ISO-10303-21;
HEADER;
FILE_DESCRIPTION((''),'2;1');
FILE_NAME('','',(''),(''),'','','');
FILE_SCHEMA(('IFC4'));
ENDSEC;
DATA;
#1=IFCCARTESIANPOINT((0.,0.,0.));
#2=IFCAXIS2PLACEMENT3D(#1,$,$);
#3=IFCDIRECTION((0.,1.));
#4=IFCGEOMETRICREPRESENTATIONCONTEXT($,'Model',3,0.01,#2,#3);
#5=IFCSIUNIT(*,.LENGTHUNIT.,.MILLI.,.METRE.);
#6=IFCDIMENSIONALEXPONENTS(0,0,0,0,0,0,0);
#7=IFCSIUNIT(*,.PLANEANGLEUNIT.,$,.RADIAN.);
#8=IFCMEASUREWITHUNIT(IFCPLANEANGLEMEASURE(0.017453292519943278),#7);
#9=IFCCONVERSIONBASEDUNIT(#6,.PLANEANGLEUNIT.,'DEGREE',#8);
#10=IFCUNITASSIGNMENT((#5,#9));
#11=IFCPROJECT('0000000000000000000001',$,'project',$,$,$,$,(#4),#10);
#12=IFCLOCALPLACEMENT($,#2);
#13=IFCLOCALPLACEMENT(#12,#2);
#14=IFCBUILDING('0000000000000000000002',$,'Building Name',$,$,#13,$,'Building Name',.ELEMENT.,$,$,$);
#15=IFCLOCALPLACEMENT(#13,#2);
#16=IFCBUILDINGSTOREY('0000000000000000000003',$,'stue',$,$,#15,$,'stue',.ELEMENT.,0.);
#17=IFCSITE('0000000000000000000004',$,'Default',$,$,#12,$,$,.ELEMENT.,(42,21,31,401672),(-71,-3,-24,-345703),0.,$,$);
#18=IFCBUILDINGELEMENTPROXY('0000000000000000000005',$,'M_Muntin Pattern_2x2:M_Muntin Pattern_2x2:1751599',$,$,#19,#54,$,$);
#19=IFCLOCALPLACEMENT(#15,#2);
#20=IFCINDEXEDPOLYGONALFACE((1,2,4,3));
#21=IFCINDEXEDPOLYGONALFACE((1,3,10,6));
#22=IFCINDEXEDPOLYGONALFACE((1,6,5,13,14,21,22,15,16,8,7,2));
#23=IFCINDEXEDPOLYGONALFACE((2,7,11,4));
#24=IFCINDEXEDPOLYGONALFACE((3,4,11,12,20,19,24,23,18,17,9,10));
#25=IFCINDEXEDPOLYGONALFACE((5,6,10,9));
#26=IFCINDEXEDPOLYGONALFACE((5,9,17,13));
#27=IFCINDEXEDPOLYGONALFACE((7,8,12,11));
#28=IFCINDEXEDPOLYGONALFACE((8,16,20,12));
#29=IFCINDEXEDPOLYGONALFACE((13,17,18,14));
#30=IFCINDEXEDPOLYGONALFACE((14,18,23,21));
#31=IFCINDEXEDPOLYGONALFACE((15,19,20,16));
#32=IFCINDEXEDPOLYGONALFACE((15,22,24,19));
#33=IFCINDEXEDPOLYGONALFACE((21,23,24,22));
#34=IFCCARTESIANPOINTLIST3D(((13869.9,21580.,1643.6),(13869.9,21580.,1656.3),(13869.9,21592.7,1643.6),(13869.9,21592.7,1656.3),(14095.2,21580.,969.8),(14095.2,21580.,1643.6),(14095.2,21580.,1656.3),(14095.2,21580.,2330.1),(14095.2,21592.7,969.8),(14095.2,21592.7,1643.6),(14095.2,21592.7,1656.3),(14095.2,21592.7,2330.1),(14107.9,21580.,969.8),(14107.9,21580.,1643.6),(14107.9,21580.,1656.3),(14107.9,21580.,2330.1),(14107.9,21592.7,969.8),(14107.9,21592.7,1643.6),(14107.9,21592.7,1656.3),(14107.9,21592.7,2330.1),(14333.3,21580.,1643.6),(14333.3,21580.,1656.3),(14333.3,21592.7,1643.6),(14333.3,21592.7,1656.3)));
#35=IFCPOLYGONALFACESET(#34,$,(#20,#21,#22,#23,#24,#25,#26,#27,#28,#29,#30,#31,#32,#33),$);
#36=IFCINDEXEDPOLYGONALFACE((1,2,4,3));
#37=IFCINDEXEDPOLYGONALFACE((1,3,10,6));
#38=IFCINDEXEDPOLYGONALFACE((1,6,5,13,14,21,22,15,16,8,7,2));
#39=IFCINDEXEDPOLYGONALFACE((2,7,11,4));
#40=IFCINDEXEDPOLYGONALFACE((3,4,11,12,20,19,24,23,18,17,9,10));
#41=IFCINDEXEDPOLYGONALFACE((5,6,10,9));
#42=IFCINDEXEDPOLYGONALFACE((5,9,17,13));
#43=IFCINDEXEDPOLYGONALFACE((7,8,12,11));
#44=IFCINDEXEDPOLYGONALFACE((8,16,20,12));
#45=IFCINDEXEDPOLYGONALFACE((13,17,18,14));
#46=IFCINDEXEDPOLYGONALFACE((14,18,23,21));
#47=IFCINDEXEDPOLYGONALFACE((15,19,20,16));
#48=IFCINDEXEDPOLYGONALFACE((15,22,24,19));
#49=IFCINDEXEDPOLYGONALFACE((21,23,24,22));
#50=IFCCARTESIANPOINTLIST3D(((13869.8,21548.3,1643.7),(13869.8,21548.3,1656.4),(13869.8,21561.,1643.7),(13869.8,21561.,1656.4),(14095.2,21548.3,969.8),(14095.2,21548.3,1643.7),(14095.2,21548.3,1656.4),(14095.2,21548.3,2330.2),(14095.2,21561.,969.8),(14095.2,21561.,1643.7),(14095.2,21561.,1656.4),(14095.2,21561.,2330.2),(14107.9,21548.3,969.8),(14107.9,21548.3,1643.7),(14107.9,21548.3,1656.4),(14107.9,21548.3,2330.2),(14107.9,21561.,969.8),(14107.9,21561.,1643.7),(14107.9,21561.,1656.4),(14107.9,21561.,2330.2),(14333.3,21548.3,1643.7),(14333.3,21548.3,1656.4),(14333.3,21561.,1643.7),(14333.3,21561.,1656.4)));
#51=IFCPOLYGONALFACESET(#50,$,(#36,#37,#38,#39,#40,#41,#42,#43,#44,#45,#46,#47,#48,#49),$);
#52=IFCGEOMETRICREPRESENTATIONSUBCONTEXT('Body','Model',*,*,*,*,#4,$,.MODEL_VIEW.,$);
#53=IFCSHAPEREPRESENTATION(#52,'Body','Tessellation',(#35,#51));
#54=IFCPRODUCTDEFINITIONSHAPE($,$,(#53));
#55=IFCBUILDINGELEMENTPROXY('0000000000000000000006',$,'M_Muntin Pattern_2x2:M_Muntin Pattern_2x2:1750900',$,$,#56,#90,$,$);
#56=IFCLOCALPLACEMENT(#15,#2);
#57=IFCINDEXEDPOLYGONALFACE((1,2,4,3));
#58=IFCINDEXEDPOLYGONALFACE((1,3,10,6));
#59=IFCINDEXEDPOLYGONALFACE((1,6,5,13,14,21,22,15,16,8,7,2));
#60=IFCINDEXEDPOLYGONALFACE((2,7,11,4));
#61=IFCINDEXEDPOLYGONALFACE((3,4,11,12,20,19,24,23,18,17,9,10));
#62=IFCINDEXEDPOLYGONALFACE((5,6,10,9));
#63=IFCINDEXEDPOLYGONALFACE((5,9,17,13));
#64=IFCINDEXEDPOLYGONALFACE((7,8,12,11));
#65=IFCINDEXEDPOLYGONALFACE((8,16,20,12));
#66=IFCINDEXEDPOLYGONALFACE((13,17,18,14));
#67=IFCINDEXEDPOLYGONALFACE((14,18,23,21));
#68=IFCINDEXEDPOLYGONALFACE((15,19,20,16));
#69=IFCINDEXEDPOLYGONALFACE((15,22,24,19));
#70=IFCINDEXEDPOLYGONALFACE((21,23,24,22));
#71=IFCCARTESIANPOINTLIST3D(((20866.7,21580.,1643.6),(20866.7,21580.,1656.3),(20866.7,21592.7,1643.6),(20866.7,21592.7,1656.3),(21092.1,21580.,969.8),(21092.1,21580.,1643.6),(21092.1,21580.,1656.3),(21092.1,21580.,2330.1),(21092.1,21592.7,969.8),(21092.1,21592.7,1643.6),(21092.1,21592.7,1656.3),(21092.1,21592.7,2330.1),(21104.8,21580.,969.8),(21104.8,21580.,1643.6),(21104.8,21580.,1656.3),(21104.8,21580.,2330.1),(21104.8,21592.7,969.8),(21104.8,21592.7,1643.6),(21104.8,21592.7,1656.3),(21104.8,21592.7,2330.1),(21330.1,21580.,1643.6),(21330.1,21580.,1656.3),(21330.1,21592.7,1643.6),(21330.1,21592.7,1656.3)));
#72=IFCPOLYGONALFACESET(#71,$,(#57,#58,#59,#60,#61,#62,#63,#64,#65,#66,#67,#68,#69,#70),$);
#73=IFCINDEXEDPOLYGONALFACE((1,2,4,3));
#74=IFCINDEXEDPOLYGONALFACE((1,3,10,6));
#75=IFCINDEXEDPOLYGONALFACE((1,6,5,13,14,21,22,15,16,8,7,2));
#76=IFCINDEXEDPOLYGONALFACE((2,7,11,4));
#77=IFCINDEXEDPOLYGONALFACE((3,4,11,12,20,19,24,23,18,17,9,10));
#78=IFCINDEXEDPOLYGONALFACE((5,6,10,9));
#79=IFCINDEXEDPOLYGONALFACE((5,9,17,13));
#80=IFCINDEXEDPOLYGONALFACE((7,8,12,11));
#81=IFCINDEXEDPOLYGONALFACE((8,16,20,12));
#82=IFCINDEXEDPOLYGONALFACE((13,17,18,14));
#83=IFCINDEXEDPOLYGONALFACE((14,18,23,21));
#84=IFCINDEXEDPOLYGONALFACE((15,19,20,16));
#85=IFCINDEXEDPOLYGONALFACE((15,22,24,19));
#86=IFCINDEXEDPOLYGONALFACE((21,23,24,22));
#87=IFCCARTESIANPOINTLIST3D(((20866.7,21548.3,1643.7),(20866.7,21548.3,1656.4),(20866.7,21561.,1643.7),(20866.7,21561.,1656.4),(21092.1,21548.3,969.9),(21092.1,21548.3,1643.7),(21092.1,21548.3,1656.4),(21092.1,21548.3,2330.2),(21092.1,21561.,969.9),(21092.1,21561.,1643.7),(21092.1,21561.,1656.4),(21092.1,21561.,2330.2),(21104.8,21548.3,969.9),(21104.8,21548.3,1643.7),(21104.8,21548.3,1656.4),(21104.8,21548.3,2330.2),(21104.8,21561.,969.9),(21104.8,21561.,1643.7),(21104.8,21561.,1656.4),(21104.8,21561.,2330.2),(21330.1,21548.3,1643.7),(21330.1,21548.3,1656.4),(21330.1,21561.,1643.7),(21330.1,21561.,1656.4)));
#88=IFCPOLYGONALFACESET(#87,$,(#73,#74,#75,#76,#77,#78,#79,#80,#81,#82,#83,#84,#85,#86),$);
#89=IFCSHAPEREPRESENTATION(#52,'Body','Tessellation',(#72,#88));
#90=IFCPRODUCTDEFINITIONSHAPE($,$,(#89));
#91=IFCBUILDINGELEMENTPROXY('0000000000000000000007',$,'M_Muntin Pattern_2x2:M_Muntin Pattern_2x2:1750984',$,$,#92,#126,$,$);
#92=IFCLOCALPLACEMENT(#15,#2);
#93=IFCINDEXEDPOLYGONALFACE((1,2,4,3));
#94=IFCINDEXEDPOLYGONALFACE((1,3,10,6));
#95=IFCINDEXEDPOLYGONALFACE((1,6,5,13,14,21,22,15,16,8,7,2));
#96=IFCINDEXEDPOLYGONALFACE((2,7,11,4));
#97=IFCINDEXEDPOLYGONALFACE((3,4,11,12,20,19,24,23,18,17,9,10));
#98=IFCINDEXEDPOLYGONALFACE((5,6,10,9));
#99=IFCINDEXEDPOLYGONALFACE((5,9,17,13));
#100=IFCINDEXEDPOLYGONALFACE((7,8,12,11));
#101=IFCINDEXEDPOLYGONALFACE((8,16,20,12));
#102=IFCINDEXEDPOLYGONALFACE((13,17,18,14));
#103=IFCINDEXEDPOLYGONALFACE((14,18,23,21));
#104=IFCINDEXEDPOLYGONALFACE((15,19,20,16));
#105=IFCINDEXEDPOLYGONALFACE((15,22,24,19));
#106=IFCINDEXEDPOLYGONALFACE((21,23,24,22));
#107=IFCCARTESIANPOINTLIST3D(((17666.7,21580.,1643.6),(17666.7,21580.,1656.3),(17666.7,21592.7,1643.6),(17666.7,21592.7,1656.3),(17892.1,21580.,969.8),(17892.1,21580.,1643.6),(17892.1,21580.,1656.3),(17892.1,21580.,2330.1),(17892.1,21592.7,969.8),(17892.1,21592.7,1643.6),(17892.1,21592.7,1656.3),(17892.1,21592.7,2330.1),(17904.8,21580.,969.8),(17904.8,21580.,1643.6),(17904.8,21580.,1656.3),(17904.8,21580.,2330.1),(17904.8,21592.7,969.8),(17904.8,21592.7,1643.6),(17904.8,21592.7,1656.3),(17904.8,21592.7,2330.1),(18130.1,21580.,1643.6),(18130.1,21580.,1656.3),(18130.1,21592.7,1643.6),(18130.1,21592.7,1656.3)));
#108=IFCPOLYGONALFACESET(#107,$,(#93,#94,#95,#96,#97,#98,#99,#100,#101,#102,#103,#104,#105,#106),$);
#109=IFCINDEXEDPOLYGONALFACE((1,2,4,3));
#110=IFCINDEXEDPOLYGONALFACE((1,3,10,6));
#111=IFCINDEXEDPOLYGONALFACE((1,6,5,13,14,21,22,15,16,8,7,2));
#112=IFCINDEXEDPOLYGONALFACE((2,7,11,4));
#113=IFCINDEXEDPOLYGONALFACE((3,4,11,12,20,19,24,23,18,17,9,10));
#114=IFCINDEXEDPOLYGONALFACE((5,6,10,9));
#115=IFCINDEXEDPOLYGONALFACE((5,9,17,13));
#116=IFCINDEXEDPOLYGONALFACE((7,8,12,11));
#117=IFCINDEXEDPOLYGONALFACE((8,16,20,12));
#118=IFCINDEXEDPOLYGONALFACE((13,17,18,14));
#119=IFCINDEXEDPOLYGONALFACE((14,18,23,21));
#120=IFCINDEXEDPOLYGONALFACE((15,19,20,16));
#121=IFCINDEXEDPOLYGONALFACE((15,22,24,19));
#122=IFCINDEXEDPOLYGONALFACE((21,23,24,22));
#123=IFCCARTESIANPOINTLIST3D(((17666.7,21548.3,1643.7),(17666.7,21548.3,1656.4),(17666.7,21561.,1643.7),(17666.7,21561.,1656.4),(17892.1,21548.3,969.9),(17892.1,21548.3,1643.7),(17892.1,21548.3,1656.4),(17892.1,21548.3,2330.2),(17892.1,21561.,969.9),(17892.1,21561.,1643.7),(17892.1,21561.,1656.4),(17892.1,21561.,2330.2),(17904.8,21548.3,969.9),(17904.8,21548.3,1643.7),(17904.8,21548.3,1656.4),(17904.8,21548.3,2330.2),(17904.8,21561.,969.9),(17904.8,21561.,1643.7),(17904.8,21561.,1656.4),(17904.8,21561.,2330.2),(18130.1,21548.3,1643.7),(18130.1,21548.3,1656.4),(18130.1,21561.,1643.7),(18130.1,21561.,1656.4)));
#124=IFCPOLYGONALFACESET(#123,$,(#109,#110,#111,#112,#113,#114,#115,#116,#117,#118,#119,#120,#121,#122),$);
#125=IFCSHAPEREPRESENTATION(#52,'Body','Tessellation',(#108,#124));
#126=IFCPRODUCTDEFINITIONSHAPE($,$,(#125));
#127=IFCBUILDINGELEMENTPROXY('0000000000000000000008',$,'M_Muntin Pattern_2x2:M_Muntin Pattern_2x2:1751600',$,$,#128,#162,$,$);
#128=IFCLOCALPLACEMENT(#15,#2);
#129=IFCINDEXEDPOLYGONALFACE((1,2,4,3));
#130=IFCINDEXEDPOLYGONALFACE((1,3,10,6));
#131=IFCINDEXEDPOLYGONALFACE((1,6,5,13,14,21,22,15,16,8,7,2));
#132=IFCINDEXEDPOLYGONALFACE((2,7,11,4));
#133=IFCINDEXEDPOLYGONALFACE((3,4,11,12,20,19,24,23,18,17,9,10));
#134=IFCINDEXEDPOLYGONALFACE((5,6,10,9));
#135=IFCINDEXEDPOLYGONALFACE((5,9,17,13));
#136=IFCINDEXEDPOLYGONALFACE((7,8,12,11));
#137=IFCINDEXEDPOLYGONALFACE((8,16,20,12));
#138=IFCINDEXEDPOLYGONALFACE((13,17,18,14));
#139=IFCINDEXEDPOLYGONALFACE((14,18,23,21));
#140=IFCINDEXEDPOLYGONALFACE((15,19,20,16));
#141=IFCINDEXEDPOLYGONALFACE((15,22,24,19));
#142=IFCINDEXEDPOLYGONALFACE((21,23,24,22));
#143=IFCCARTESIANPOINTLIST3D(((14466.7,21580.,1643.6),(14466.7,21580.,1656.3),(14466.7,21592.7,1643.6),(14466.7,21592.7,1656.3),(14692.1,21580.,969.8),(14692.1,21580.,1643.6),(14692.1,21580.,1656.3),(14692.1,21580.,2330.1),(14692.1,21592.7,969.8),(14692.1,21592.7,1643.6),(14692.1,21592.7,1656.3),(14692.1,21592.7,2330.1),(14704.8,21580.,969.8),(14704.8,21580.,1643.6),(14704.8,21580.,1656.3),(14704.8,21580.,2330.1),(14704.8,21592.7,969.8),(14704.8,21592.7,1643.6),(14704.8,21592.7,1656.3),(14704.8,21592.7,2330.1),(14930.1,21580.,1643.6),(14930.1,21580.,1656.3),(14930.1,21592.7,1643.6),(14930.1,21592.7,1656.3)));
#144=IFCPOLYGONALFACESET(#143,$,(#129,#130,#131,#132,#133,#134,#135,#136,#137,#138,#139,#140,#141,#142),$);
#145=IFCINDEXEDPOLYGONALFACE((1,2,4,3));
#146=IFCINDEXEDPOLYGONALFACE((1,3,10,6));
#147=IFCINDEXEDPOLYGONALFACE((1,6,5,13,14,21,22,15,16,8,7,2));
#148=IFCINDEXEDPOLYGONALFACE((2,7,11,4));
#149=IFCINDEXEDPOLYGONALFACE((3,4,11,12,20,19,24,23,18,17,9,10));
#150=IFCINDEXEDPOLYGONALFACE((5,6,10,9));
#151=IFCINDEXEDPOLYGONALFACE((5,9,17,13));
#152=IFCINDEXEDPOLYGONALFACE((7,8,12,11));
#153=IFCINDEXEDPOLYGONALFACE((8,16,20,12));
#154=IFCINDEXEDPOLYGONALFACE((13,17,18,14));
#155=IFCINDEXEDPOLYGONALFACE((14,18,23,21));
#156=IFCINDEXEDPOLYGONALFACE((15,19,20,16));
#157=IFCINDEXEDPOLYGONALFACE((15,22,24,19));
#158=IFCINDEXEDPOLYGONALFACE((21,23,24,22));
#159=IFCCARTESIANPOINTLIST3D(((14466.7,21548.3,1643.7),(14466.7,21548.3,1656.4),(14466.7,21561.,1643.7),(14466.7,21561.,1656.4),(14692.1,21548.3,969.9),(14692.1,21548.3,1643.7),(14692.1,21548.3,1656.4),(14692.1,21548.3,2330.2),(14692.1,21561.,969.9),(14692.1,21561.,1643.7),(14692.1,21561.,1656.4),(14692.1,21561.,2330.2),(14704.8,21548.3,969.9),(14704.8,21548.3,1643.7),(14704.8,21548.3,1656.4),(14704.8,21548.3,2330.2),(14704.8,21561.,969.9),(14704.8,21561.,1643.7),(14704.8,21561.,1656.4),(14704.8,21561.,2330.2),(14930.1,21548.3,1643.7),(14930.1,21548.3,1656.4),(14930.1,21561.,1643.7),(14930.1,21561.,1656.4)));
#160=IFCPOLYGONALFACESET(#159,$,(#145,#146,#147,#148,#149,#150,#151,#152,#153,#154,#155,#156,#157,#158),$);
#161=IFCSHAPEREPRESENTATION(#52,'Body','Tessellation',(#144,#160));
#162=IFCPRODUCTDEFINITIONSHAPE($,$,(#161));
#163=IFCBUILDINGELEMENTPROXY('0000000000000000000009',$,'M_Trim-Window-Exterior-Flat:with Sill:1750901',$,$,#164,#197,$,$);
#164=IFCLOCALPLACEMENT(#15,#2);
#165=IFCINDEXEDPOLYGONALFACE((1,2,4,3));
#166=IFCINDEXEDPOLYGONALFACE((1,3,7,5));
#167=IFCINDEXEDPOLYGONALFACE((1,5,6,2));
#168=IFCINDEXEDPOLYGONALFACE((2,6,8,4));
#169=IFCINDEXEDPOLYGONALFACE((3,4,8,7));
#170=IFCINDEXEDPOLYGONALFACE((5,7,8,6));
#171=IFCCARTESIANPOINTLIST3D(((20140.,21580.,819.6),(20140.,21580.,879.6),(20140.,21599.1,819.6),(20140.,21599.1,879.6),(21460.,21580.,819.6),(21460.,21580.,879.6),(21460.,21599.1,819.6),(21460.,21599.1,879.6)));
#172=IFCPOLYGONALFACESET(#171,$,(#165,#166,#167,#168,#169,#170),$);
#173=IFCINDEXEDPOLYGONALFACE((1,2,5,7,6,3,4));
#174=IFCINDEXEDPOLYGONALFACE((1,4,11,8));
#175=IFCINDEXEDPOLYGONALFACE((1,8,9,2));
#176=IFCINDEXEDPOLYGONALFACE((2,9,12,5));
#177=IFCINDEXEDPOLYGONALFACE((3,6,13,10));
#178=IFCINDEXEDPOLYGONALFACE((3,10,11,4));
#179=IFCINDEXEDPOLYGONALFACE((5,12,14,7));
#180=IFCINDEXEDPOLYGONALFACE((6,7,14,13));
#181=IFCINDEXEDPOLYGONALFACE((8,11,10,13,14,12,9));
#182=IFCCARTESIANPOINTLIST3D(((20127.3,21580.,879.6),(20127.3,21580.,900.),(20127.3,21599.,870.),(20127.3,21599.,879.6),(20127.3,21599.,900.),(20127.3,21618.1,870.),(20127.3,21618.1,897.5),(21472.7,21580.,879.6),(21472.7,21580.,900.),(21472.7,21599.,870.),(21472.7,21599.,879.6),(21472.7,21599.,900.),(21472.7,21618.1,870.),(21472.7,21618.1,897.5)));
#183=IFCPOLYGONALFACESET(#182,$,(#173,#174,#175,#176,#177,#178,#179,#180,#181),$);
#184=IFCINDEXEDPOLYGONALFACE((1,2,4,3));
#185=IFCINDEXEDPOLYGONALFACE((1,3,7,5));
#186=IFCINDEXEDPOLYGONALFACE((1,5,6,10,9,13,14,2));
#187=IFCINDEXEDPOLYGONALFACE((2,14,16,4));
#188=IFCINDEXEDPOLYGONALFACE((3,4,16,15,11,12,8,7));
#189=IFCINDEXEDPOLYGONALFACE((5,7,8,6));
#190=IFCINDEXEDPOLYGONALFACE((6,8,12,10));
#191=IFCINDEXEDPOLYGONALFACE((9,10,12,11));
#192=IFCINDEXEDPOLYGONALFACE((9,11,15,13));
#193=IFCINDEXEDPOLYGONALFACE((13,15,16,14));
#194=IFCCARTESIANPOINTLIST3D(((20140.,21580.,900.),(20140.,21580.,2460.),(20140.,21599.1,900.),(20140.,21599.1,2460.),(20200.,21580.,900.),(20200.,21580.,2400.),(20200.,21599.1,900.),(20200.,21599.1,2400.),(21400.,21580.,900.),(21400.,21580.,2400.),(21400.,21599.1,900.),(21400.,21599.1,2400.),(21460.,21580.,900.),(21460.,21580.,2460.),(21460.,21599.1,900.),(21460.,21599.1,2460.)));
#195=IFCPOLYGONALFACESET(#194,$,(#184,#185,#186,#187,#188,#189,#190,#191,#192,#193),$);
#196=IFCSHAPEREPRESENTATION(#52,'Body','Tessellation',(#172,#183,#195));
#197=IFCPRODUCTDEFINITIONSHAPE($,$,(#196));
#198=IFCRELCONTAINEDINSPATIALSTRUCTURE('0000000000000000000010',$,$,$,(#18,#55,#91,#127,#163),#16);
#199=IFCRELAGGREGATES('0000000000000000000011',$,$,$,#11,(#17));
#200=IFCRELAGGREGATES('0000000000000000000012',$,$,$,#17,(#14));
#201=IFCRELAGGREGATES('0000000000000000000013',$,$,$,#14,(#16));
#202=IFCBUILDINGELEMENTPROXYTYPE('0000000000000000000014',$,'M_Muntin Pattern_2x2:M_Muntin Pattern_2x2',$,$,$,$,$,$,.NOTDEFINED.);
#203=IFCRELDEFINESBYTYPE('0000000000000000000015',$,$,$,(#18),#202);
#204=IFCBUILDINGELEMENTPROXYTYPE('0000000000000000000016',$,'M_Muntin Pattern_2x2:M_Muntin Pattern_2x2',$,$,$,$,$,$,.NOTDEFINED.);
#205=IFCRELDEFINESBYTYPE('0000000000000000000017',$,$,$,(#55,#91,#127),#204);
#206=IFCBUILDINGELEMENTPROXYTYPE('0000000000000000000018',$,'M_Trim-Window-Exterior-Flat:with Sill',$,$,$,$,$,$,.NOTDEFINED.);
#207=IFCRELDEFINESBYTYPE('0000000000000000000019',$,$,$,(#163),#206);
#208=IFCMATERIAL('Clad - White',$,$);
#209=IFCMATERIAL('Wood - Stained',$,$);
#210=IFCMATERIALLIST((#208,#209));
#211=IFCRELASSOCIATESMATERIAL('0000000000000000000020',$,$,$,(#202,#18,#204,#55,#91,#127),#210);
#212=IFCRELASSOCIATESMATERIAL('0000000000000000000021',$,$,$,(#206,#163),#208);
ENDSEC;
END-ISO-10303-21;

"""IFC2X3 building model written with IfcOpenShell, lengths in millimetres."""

from ifc_helpers import new_model, entity, si_unit, converted_unit, direction, frame, frame_2d, origin, place, context, subcontext, project, spatial, polyline, rectangle, outline, extrude, source, transform, mapped, material, material_list, type_object, type_shapes, element, save


model = new_model("IFC2X3")

# Units and contexts
model_context = context("Model", 3, precision=0.01, world=origin(), true_north=direction((0.0, 1.0)))
body_context = subcontext(model_context, "Body", "Model", "MODEL_VIEW")
ifc_project = project(units=[si_unit("LENGTHUNIT", "METRE", prefix="MILLI"), converted_unit("PLANEANGLEUNIT", "DEGREE", entity("IfcPlaneAngleMeasure", 0.017453292519943278), si_unit("PLANEANGLEUNIT", "RADIAN"), dimensions=[0, 0, 0, 0, 0, 0, 0])], contexts=[model_context])

# Site, building, storey
site_placement = place(None, origin())
site = spatial("IfcSite", under=ifc_project, at=site_placement, Name="Default", CompositionType="ELEMENT", RefLatitude=(42, 21, 31, 401672), RefLongitude=(-71, -3, -24, -345703), RefElevation=0.0)
building_placement = place(site_placement, origin())
building = spatial("IfcBuilding", under=site, at=building_placement, Name="Building Name", LongName="Building Name", CompositionType="ELEMENT")
storey_placement = place(building_placement, origin())
storey = spatial("IfcBuildingStorey", under=building, at=storey_placement, Name="stue", LongName="stue", CompositionType="ELEMENT", Elevation=0.0)

# Building element proxies
ifc_material_1 = material(Name="Clad - White")
ifc_material_2 = material(Name="Wood - Stained")
ifc_material_list = material_list([ifc_material_1, ifc_material_2])
building_element_proxy_type_1 = type_object("IfcBuildingElementProxyType", Name="M_Muntin Pattern_2x2:M_Muntin Pattern_2x2", PredefinedType="NOTDEFINED", material=ifc_material_list)
shared_shape_1 = source(origin(), body_context, "Body", "SweptSolid", [
    extrude(outline(polyline([(6.4, -6.4), (680.1, -6.4), (680.1, 6.3), (6.4, 6.3), (6.4, 231.7), (-6.3, 231.7), (-6.3, 6.3), (-680.2, 6.3), (-680.2, -6.4), (-6.3, -6.4), (-6.3, -231.7), (6.4, -231.7), (6.4, -6.4)])), frame((0.0, 9.5, 680.1), z_axis=(0.0, 1.0, 0.0), x_axis=(0.0, 0.0, 1.0)), (0.0, 0.0, 1.0), 12.7),
    extrude(outline(polyline([(6.4, -6.4), (680.2, -6.4), (680.2, 6.3), (6.4, 6.3), (6.4, 231.7), (-6.3, 231.7), (-6.3, 6.3), (-680.2, 6.3), (-680.2, -6.4), (-6.3, -6.4), (-6.3, -231.7), (6.4, -231.7), (6.4, -6.4)])), frame((0.0, -22.2, 680.2), z_axis=(0.0, 1.0, 0.0), x_axis=(0.0, 0.0, 1.0)), (0.0, 0.0, 1.0), 12.7),
])
type_shapes(building_element_proxy_type_1, [shared_shape_1])
for number, where, name in (
    (1, (14101.6, 21570.5, 969.8), "M_Muntin Pattern_2x2:M_Muntin Pattern_2x2:1751599"),
):
    element("IfcBuildingElementProxy", number, at=place(storey_placement, frame(where)), inside=storey, type_object=building_element_proxy_type_1, material=ifc_material_list, Name=name, context=body_context, shape_type="MappedRepresentation", body=[
        mapped(shared_shape_1, transform((0.0, 0.0, 0.0), scale=1.0)),
    ])
building_element_proxy_type_2 = type_object("IfcBuildingElementProxyType", Name="M_Muntin Pattern_2x2:M_Muntin Pattern_2x2", PredefinedType="NOTDEFINED", material=ifc_material_list)
shared_shape_2 = source(origin(), body_context, "Body", "SweptSolid", [
    extrude(outline(polyline([(6.4, -6.4), (680.1, -6.4), (680.1, 6.3), (6.4, 6.3), (6.4, 231.7), (-6.3, 231.7), (-6.3, 6.3), (-680.2, 6.3), (-680.2, -6.4), (-6.3, -6.4), (-6.3, -231.7), (6.4, -231.7), (6.4, -6.4)])), frame((0.0, -22.2, 680.1), z_axis=(0.0, 1.0, 0.0), x_axis=(0.0, 0.0, 1.0)), (0.0, 0.0, 1.0), 12.7),
    extrude(outline(polyline([(6.4, -6.4), (680.2, -6.4), (680.2, 6.3), (6.4, 6.3), (6.4, 231.7), (-6.3, 231.7), (-6.3, 6.3), (-680.2, 6.3), (-680.2, -6.4), (-6.3, -6.4), (-6.3, -231.7), (6.4, -231.7), (6.4, -6.4)])), frame((0.0, 9.5, 680.2), z_axis=(0.0, 1.0, 0.0), x_axis=(0.0, 0.0, 1.0)), (0.0, 0.0, 1.0), 12.7),
])
type_shapes(building_element_proxy_type_2, [shared_shape_2])
for number, where, z_axis, x_axis, name in (
    (2, (21098.4, 21570.5, 969.9), (0.0, 0.0, 1.0), (-1.0, 0.0, 0.0), "M_Muntin Pattern_2x2:M_Muntin Pattern_2x2:1750900"),
    (3, (17898.4, 21570.5, 969.9), (0.0, 0.0, 1.0), (-1.0, 0.0, 0.0), "M_Muntin Pattern_2x2:M_Muntin Pattern_2x2:1750984"),
    (4, (14698.4, 21570.5, 969.9), (0.0, 0.0, 1.0), (-1.0, 0.0, 0.0), "M_Muntin Pattern_2x2:M_Muntin Pattern_2x2:1751600"),
):
    element("IfcBuildingElementProxy", number, at=place(storey_placement, frame(where, z_axis=z_axis, x_axis=x_axis)), inside=storey, type_object=building_element_proxy_type_2, material=ifc_material_list, Name=name, context=body_context, shape_type="MappedRepresentation", body=[
        mapped(shared_shape_2, transform((0.0, 0.0, 0.0), scale=1.0)),
    ])
building_element_proxy_type_3 = type_object("IfcBuildingElementProxyType", Name="M_Trim-Window-Exterior-Flat:with Sill", PredefinedType="NOTDEFINED", material=ifc_material_1)
shared_shape_3 = source(origin(), body_context, "Body", "SweptSolid", [
    extrude(rectangle(XDim=1320.0, YDim=60.0, at=frame_2d((0.0, 0.0), x_axis=(1.0, 0.0))), frame((0.0, -1550.4, 0.0), z_axis=(0.0, 0.0, 1.0), x_axis=(-1.0, 0.0, 0.0)), (0.0, 0.0, 1.0), 19.0),
    extrude(outline(polyline([(-19.0, -15.2), (0.0, -15.2), (0.0, -5.7), (19.0, -5.7), (19.0, 14.8), (0.0, 14.8), (-19.0, 12.3), (-19.0, -15.2)])), frame((-672.7, -1514.8, 19.0), z_axis=(1.0, 0.0, 0.0), x_axis=(0.0, 0.0, -1.0)), (0.0, 0.0, 1.0), 1345.4),
    extrude(outline(polyline([(-795.0, -660.0), (765.0, -660.0), (765.0, -600.0), (-735.0, -600.0), (-735.0, 600.0), (765.0, 600.0), (765.0, 660.0), (-795.0, 660.0), (-795.0, -660.0)])), frame((0.0, -735.0, 0.0), z_axis=(0.0, 0.0, 1.0), x_axis=(0.0, -1.0, 0.0)), (0.0, 0.0, 1.0), 19.0),
])
type_shapes(building_element_proxy_type_3, [shared_shape_3])
for number, where, z_axis, x_axis, name in (
    (5, (20800.0, 21580.0, 2400.0), (0.0, 1.0, 0.0), (-1.0, 0.0, 0.0), "M_Trim-Window-Exterior-Flat:with Sill:1750901"),
):
    element("IfcBuildingElementProxy", number, at=place(storey_placement, frame(where, z_axis=z_axis, x_axis=x_axis)), inside=storey, type_object=building_element_proxy_type_3, material=ifc_material_1, Name=name, context=body_context, shape_type="MappedRepresentation", body=[
        mapped(shared_shape_3, transform((0.0, 0.0, 0.0), scale=1.0)),
    ])

save(model, "model.ifc")
